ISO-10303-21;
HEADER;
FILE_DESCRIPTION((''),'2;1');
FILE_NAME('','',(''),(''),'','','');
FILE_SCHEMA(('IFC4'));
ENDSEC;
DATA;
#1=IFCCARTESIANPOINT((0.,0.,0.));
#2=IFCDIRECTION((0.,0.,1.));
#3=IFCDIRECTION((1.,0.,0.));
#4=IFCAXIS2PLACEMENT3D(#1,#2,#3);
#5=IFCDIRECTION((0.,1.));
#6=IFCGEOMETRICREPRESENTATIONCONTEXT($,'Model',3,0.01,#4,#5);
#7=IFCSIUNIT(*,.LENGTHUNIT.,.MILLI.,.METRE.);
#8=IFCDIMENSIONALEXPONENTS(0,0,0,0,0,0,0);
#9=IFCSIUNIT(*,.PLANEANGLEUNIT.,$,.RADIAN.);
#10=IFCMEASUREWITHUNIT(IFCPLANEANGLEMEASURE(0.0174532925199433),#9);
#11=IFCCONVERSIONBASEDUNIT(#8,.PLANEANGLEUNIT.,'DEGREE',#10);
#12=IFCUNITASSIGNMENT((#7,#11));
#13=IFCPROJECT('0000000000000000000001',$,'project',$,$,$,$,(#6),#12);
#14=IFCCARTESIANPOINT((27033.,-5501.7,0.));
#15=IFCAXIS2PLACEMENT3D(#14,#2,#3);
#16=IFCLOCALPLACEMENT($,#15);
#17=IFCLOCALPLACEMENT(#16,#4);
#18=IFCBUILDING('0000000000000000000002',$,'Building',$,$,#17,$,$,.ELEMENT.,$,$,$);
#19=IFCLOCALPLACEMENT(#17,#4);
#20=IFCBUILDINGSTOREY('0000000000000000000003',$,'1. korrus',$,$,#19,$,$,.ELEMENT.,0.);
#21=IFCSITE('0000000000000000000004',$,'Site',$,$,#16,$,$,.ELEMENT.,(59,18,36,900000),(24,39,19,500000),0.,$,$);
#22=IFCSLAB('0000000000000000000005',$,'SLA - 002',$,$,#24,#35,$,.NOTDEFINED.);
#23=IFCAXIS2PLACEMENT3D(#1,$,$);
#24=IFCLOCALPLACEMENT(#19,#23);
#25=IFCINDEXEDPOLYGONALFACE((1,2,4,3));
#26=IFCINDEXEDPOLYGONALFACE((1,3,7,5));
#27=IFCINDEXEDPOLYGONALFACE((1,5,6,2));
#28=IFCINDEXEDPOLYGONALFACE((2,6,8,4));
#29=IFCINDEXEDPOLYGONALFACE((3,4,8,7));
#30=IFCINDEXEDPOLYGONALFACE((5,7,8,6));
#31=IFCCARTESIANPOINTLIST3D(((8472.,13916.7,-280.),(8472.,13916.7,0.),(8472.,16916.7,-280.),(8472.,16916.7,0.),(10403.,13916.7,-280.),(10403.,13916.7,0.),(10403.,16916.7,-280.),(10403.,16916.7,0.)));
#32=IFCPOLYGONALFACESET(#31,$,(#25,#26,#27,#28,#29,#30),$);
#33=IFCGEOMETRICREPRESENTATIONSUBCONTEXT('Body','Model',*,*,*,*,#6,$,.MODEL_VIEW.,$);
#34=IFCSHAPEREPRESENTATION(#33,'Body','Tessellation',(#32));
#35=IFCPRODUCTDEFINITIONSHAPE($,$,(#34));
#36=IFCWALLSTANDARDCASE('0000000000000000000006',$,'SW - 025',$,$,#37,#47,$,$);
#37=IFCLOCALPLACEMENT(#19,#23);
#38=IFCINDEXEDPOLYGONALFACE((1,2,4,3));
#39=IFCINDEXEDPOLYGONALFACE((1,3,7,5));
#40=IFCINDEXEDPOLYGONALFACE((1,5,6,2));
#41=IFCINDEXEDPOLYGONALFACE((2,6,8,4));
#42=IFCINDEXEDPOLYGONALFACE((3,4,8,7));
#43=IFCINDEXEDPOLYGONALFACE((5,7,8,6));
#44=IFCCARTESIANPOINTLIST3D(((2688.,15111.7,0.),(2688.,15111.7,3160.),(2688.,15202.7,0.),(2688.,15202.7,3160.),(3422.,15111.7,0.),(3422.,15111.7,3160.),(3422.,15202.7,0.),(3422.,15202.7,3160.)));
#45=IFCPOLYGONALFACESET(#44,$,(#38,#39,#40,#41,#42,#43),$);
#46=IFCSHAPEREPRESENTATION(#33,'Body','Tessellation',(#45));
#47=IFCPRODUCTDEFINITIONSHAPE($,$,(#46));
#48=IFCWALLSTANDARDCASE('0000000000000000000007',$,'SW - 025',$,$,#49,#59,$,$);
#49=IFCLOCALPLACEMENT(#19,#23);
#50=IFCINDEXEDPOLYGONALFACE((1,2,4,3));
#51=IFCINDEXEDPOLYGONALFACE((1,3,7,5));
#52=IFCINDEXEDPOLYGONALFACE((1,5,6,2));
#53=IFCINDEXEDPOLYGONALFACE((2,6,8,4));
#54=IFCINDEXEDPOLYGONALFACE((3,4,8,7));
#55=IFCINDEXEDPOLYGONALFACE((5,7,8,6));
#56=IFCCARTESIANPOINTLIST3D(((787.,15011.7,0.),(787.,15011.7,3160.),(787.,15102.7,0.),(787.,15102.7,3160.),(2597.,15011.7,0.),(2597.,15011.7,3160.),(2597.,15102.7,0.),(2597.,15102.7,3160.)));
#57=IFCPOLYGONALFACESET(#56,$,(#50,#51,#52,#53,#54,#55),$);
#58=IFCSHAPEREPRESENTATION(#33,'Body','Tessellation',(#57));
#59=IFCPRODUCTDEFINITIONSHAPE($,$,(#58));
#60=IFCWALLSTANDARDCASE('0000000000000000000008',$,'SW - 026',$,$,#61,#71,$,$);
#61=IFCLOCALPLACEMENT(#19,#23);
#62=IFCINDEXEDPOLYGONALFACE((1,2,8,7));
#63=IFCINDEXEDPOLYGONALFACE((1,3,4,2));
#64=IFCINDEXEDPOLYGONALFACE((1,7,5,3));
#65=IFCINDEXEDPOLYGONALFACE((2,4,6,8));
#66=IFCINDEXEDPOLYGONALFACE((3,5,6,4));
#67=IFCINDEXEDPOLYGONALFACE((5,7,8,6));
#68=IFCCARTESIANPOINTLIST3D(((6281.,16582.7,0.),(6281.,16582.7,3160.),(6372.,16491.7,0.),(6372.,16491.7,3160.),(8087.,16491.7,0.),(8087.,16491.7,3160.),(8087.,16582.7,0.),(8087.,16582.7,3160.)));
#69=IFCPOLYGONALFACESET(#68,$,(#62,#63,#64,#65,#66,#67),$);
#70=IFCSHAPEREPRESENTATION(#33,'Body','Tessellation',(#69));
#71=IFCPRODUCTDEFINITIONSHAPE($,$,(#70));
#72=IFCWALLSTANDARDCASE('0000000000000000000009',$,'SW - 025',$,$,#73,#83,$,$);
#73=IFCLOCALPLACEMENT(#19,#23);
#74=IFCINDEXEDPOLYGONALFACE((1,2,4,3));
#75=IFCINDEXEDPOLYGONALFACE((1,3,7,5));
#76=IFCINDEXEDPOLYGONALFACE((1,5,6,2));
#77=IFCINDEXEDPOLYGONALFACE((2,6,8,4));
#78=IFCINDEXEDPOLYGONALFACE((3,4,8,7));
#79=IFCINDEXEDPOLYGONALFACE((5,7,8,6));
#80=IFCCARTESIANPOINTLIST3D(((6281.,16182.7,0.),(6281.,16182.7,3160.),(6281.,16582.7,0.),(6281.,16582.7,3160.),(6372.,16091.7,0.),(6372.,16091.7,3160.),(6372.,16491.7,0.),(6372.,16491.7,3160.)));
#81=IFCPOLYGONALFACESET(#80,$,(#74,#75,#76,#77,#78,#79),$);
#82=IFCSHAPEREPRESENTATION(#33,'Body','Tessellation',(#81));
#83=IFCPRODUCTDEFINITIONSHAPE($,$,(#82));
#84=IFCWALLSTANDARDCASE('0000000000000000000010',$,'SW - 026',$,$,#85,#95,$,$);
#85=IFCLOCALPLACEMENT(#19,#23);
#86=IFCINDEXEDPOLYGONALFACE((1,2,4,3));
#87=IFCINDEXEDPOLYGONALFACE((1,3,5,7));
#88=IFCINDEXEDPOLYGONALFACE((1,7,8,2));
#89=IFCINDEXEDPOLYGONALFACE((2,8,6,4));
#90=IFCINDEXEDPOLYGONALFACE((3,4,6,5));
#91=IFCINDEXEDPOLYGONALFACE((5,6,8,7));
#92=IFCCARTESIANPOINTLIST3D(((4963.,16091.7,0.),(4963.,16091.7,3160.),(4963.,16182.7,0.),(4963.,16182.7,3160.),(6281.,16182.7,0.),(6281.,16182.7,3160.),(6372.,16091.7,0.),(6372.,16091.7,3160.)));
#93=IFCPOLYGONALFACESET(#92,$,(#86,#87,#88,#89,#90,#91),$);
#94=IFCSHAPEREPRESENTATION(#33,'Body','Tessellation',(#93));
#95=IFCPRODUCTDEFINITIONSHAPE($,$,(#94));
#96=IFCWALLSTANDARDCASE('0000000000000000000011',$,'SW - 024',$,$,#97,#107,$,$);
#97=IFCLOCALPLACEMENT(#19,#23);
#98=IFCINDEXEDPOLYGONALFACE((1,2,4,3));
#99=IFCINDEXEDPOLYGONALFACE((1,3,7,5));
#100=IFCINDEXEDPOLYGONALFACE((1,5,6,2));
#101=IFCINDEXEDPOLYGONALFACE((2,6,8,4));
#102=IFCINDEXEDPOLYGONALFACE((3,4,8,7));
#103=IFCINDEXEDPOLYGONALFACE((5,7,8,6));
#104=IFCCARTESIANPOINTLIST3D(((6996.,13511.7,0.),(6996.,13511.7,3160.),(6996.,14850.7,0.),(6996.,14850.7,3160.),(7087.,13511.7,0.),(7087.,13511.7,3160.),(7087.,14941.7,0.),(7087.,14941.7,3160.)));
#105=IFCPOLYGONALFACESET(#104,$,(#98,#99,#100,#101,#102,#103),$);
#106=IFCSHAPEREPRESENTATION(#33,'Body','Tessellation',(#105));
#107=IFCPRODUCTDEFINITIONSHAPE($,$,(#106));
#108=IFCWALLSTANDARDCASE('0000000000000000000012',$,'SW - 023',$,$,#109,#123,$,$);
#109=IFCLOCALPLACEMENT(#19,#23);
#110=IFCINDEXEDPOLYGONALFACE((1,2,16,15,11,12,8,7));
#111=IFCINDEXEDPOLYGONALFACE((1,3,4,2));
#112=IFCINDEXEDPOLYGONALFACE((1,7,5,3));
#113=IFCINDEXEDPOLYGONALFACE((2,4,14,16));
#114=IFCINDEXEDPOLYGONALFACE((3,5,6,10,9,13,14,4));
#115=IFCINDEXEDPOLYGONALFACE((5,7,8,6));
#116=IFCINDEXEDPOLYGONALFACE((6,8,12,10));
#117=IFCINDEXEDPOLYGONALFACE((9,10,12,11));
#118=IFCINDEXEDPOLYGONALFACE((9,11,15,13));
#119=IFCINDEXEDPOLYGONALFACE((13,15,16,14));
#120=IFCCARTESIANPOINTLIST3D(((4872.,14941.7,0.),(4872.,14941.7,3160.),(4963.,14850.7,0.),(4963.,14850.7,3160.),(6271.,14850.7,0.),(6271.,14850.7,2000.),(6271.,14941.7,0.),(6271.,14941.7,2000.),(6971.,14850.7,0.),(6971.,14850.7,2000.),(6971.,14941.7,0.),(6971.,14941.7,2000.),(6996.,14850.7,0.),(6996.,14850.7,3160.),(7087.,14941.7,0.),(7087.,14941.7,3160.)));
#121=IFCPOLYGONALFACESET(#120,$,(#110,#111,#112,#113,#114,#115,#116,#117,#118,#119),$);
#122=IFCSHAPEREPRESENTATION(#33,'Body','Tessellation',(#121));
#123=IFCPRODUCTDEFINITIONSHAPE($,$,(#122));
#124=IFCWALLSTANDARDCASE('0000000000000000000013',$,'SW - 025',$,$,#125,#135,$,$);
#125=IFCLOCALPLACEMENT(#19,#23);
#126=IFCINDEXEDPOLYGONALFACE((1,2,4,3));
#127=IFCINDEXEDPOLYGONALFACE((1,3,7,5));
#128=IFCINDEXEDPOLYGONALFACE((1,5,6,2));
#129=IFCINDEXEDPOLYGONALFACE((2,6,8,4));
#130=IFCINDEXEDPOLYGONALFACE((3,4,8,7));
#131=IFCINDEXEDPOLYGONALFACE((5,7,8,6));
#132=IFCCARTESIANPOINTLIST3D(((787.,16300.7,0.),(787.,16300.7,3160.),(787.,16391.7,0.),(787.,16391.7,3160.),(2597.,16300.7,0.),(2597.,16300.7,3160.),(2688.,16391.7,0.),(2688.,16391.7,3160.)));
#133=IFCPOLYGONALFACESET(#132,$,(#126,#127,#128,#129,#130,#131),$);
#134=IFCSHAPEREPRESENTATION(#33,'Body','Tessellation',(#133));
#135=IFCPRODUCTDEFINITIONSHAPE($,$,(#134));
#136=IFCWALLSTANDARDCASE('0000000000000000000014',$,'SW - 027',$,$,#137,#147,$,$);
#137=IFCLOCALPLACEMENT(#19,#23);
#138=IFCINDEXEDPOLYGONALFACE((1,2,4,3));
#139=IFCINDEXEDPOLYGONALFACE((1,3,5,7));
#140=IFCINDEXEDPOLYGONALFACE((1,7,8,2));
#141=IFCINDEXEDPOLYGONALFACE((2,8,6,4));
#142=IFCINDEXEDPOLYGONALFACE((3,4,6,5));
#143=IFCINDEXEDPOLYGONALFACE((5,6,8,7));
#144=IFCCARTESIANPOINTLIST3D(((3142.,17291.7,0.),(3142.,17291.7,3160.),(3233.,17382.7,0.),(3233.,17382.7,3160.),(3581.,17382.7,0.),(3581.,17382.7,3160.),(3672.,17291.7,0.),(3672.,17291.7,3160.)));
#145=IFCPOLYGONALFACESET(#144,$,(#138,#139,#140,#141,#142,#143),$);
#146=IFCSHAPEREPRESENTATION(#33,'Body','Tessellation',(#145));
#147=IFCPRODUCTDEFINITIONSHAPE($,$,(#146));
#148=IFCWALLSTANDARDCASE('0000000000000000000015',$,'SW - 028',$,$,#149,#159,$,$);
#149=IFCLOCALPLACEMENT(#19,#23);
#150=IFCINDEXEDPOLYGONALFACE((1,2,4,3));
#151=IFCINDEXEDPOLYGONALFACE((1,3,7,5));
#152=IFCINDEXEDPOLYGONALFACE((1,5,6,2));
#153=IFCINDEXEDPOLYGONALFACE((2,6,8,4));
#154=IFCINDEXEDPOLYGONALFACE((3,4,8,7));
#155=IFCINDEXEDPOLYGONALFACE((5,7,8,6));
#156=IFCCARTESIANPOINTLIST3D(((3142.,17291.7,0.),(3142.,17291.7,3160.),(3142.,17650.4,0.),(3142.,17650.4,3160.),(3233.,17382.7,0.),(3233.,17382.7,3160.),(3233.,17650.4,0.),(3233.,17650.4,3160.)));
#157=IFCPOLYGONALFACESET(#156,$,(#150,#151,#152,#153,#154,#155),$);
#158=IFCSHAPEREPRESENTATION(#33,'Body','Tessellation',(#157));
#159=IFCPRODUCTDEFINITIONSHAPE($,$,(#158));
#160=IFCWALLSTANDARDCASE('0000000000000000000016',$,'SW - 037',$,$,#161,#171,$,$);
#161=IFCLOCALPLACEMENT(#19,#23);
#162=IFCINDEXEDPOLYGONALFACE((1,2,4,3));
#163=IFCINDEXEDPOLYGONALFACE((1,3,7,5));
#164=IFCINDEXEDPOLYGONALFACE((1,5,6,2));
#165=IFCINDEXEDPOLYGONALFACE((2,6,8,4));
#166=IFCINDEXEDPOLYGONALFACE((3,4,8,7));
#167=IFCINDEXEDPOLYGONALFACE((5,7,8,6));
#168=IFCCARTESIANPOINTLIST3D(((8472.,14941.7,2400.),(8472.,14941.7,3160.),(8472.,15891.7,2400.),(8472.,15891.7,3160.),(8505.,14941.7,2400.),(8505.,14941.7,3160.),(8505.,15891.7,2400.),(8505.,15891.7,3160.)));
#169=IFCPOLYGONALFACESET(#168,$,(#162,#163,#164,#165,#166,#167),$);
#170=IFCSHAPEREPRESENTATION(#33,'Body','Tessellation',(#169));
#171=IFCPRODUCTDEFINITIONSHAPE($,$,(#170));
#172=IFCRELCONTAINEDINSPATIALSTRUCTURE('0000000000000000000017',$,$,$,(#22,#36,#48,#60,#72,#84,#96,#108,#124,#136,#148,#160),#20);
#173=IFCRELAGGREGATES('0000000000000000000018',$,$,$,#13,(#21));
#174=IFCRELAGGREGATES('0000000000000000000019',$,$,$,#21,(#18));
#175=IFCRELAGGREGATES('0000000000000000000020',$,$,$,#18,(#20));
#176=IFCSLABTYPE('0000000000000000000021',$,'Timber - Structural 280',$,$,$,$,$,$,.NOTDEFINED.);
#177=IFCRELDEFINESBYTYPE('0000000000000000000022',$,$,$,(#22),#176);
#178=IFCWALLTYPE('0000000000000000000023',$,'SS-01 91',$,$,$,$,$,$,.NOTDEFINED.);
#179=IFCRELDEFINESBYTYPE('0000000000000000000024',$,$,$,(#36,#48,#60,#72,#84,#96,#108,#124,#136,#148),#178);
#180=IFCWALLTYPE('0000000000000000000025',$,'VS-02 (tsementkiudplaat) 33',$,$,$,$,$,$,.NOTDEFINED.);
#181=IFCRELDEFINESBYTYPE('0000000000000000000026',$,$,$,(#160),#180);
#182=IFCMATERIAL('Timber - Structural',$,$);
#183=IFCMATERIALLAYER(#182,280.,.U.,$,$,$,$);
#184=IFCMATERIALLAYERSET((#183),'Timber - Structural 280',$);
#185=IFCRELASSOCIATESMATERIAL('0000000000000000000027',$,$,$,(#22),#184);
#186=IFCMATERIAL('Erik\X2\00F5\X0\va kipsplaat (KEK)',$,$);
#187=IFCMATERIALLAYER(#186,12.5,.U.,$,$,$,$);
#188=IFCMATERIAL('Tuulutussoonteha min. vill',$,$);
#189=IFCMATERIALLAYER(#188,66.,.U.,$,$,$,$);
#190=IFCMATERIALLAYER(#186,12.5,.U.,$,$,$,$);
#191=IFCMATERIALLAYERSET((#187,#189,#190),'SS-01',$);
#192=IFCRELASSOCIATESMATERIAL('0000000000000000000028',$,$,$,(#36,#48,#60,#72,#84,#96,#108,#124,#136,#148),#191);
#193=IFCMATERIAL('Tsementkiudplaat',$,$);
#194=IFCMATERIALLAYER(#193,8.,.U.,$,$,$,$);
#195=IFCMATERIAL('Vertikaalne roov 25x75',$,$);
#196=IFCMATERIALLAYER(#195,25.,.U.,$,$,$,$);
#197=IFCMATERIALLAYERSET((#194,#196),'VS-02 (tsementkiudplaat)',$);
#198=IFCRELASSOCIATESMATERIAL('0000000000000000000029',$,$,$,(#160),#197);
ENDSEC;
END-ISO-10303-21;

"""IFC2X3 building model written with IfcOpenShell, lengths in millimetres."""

from ifc_helpers import new_model, entity, si_unit, converted_unit, direction, frame, origin_with_axes, origin_2d_with_axis, place, context, subcontext, project, spatial, polyline, rectangle, outline, extrude, material, layer, layer_set, layer_usage, type_object, element, save


model = new_model("IFC2X3")

# Units and contexts
model_context = context("Model", 3, precision=0.01, world=origin_with_axes(), true_north=direction((0.0, 1.0)))
body_context = subcontext(model_context, "Body", "Model", "MODEL_VIEW")
ifc_project = project(units=[si_unit("LENGTHUNIT", "METRE", prefix="MILLI"), converted_unit("PLANEANGLEUNIT", "DEGREE", entity("IfcPlaneAngleMeasure", 0.0174532925199433), si_unit("PLANEANGLEUNIT", "RADIAN"), dimensions=[0, 0, 0, 0, 0, 0, 0])], contexts=[model_context])

# Site, building, storey
site_placement = place(None, frame((27033.0, -5501.7, 0.0), z_axis=(0.0, 0.0, 1.0), x_axis=(1.0, 0.0, 0.0)))
site = spatial("IfcSite", under=ifc_project, at=site_placement, Name="Site", CompositionType="ELEMENT", RefLatitude=(59, 18, 36, 900000), RefLongitude=(24, 39, 19, 500000), RefElevation=0.0)
building_placement = place(site_placement, origin_with_axes())
building = spatial("IfcBuilding", under=site, at=building_placement, Name="Building", CompositionType="ELEMENT")
storey_placement = place(building_placement, origin_with_axes())
storey = spatial("IfcBuildingStorey", under=building, at=storey_placement, Name="1. korrus", CompositionType="ELEMENT", Elevation=0.0)

# Slab
ifc_material_1 = material(Name="Timber - Structural")
ifc_layer_1 = layer(ifc_material_1, 280.0, ventilated="UNKNOWN")
ifc_layer_set_1 = layer_set([ifc_layer_1], Name="Timber - Structural 280")
ifc_layer_usage_1 = layer_usage(ifc_layer_set_1, "AXIS3", "NEGATIVE", 280.0)
slab_type = type_object("IfcSlabType", Name="Timber - Structural 280", PredefinedType="NOTDEFINED")
slab_placement = place(storey_placement, frame((10403.0, 16916.7, 0.0), z_axis=(0.0, 0.0, 1.0), x_axis=(1.0, 0.0, 0.0)))
element("IfcSlab", 1, at=slab_placement, inside=storey, type_object=slab_type, material=ifc_layer_usage_1, Name="SLA - 002", PredefinedType="NOTDEFINED", context=body_context, shape_type="SweptSolid", body=[
    extrude(outline(polyline([(0.0, 0.0), (-1931.0, 0.0), (-1931.0, -3000.0), (0.0, -3000.0), (0.0, 0.0)])), frame((0.0, 0.0, -280.0), z_axis=(0.0, 0.0, 1.0), x_axis=(1.0, 0.0, 0.0)), (0.0, 0.0, 1.0), 280.0),
])

# Walls
ifc_material_2 = material(Name="Erikõva kipsplaat (KEK)")
ifc_layer_2 = layer(ifc_material_2, 12.5, ventilated="UNKNOWN")
ifc_material_3 = material(Name="Tuulutussoonteha min. vill")
ifc_layer_3 = layer(ifc_material_3, 66.0, ventilated="UNKNOWN")
ifc_layer_4 = layer(ifc_material_2, 12.5, ventilated="UNKNOWN")
ifc_layer_set_2 = layer_set([ifc_layer_2, ifc_layer_3, ifc_layer_4], Name="SS-01")
ifc_layer_usage_2 = layer_usage(ifc_layer_set_2, "AXIS2", "NEGATIVE", 91.0)
wall_type_1 = type_object("IfcWallType", Name="SS-01 91", PredefinedType="NOTDEFINED")
wall_1_placement = place(storey_placement, frame((3422.0, 15202.7, 0.0), z_axis=(0.0, 0.0, 1.0), x_axis=(-1.0, 0.0, 0.0)))
element("IfcWallStandardCase", 2, at=wall_1_placement, inside=storey, type_object=wall_type_1, material=ifc_layer_usage_2, Name="SW - 025", context=body_context, shape_type="SweptSolid", body=[
    extrude(outline(polyline([(0.0, 0.0), (734.0, 0.0), (734.0, 91.0), (0.0, 91.0), (0.0, 0.0)])), origin_with_axes(), (0.0, 0.0, 1.0), 3160.0),
])
ifc_layer_usage_3 = layer_usage(ifc_layer_set_2, "AXIS2", "NEGATIVE", 91.0)
wall_2_placement = place(storey_placement, frame((787.0, 15011.7, 0.0), z_axis=(0.0, 0.0, 1.0), x_axis=(1.0, 0.0, 0.0)))
element("IfcWallStandardCase", 3, at=wall_2_placement, inside=storey, type_object=wall_type_1, material=ifc_layer_usage_3, Name="SW - 025", context=body_context, shape_type="SweptSolid", body=[
    extrude(outline(polyline([(0.0, 0.0), (1810.0, 0.0), (1810.0, 91.0), (0.0, 91.0), (0.0, 0.0)])), origin_with_axes(), (0.0, 0.0, 1.0), 3160.0),
])

# Walls
ifc_layer_usage_4 = layer_usage(ifc_layer_set_2, "AXIS2", "NEGATIVE", 91.0)
wall_3_placement = place(storey_placement, frame((6372.0, 16491.7, 0.0), z_axis=(0.0, 0.0, 1.0), x_axis=(1.0, 0.0, 0.0)))
element("IfcWallStandardCase", 4, at=wall_3_placement, inside=storey, type_object=wall_type_1, material=ifc_layer_usage_4, Name="SW - 026", context=body_context, shape_type="SweptSolid", body=[
    extrude(outline(polyline([(0.0, 0.0), (1715.0, 0.0), (1715.0, 91.0), (-91.0, 91.0), (0.0, 0.0)])), origin_with_axes(), (0.0, 0.0, 1.0), 3160.0),
])
ifc_layer_usage_5 = layer_usage(ifc_layer_set_2, "AXIS2", "NEGATIVE", 91.0)
wall_4_placement = place(storey_placement, frame((6372.0, 16091.7, 0.0), z_axis=(0.0, 0.0, 1.0), x_axis=(0.0, 1.0, 0.0)))
element("IfcWallStandardCase", 5, at=wall_4_placement, inside=storey, type_object=wall_type_1, material=ifc_layer_usage_5, Name="SW - 025", context=body_context, shape_type="SweptSolid", body=[
    extrude(outline(polyline([(0.0, 0.0), (400.0, 0.0), (491.0, 91.0), (91.0, 91.0), (0.0, 0.0)])), origin_with_axes(), (0.0, 0.0, 1.0), 3160.0),
])
ifc_layer_usage_6 = layer_usage(ifc_layer_set_2, "AXIS2", "POSITIVE", -91.0)
wall_5_placement = place(storey_placement, frame((6372.0, 16091.7, 0.0), z_axis=(0.0, 0.0, 1.0), x_axis=(-1.0, 0.0, 0.0)))
element("IfcWallStandardCase", 6, at=wall_5_placement, inside=storey, type_object=wall_type_1, material=ifc_layer_usage_6, Name="SW - 026", context=body_context, shape_type="SweptSolid", body=[
    extrude(outline(polyline([(91.0, -91.0), (1409.0, -91.0), (1409.0, 0.0), (0.0, 0.0), (91.0, -91.0)])), origin_with_axes(), (0.0, 0.0, 1.0), 3160.0),
])
ifc_layer_usage_7 = layer_usage(ifc_layer_set_2, "AXIS2", "POSITIVE", -91.0)
wall_6_placement = place(storey_placement, frame((7087.0, 14941.7, 0.0), z_axis=(0.0, 0.0, 1.0), x_axis=(0.000021, -1.0, 0.0)))
element("IfcWallStandardCase", 7, at=wall_6_placement, inside=storey, type_object=wall_type_1, material=ifc_layer_usage_7, Name="SW - 024", context=body_context, shape_type="SweptSolid", body=[
    extrude(outline(polyline([(91.0, -91.0), (1430.0, -91.0), (1430.0, 0.0), (0.0, 0.0), (91.0, -91.0)])), origin_with_axes(), (0.0, 0.0, 1.0), 3160.0),
])

# Wall, opening
ifc_layer_usage_8 = layer_usage(ifc_layer_set_2, "AXIS2", "POSITIVE", -91.0)
wall_7_placement = place(storey_placement, frame((4872.0, 14941.7, 0.0), z_axis=(0.0, 0.0, 1.0), x_axis=(1.0, -0.000001, 0.0)))
wall_7 = element("IfcWallStandardCase", 8, at=wall_7_placement, inside=storey, type_object=wall_type_1, material=ifc_layer_usage_8, Name="SW - 023", context=body_context, shape_type="SweptSolid", body=[
    extrude(outline(polyline([(91.0, -91.0), (2124.0, -91.0), (2215.0, 0.0), (0.0, 0.0), (91.0, -91.0)])), origin_with_axes(), (0.0, 0.0, 1.0), 3160.0),
])
opening_1_placement = place(wall_7_placement, frame((1749.0, 0.0, 0.0), z_axis=(0.0, 0.0, 1.0), x_axis=(1.0, 0.0, 0.0)))
element("IfcOpeningElement", 9, at=opening_1_placement, cuts=wall_7, context=body_context, shape_type="SweptSolid", body=[
    extrude(rectangle(XDim=700.0, YDim=2000.0, at=origin_2d_with_axis()), frame((0.0, -91.0, 1000.0), z_axis=(0.0, -1.0, 0.0), x_axis=(-1.0, 0.0, 0.0)), (0.0, 0.0, -1.0), 273.0),
])

# Walls
ifc_layer_usage_9 = layer_usage(ifc_layer_set_2, "AXIS2", "POSITIVE", -91.0)
wall_8_placement = place(storey_placement, frame((787.0, 16391.7, 0.0), z_axis=(0.0, 0.0, 1.0), x_axis=(1.0, 0.0, 0.0)))
element("IfcWallStandardCase", 10, at=wall_8_placement, inside=storey, type_object=wall_type_1, material=ifc_layer_usage_9, Name="SW - 025", context=body_context, shape_type="SweptSolid", body=[
    extrude(outline(polyline([(0.0, -91.0), (1810.0, -91.0), (1901.0, 0.0), (0.0, 0.0), (0.0, -91.0)])), origin_with_axes(), (0.0, 0.0, 1.0), 3160.0),
])
ifc_layer_usage_10 = layer_usage(ifc_layer_set_2, "AXIS2", "POSITIVE", -91.0)
wall_9_placement = place(storey_placement, frame((3672.0, 17291.7, 0.0), z_axis=(0.0, 0.0, 1.0), x_axis=(-1.0, 0.0, 0.0)))
element("IfcWallStandardCase", 11, at=wall_9_placement, inside=storey, type_object=wall_type_1, material=ifc_layer_usage_10, Name="SW - 027", context=body_context, shape_type="SweptSolid", body=[
    extrude(outline(polyline([(91.0, -91.0), (439.0, -91.0), (530.0, 0.0), (0.0, 0.0), (91.0, -91.0)])), origin_with_axes(), (0.0, 0.0, 1.0), 3160.0),
])
ifc_layer_usage_11 = layer_usage(ifc_layer_set_2, "AXIS2", "POSITIVE", -91.0)
wall_10_placement = place(storey_placement, frame((3142.0, 17291.7, 0.0), z_axis=(0.0, 0.0, 1.0), x_axis=(0.0, 1.0, 0.0)))
element("IfcWallStandardCase", 12, at=wall_10_placement, inside=storey, type_object=wall_type_1, material=ifc_layer_usage_11, Name="SW - 028", context=body_context, shape_type="SweptSolid", body=[
    extrude(outline(polyline([(91.0, -91.0), (358.7, -91.0), (358.7, 0.0), (0.0, 0.0), (91.0, -91.0)])), origin_with_axes(), (0.0, 0.0, 1.0), 3160.0),
])
ifc_material_4 = material(Name="Tsementkiudplaat")
ifc_layer_5 = layer(ifc_material_4, 8.0, ventilated="UNKNOWN")
ifc_material_5 = material(Name="Vertikaalne roov 25x75")
ifc_layer_6 = layer(ifc_material_5, 25.0, ventilated="UNKNOWN")
ifc_layer_set_3 = layer_set([ifc_layer_5, ifc_layer_6], Name="VS-02 (tsementkiudplaat)")
ifc_layer_usage_12 = layer_usage(ifc_layer_set_3, "AXIS2", "POSITIVE", -33.0)
wall_type_2 = type_object("IfcWallType", Name="VS-02 (tsementkiudplaat) 33", PredefinedType="NOTDEFINED")
wall_11_placement = place(storey_placement, frame((8472.0, 14941.7, 2400.0), z_axis=(0.0, 0.0, 1.0), x_axis=(0.0, 1.0, 0.0)))
element("IfcWallStandardCase", 13, at=wall_11_placement, inside=storey, type_object=wall_type_2, material=ifc_layer_usage_12, Name="SW - 037", context=body_context, shape_type="SweptSolid", body=[
    extrude(outline(polyline([(0.0, -33.0), (950.0, -33.0), (950.0, 0.0), (0.0, 0.0), (0.0, -33.0)])), origin_with_axes(), (0.0, 0.0, 1.0), 760.0),
])

save(model, "model.ifc")
